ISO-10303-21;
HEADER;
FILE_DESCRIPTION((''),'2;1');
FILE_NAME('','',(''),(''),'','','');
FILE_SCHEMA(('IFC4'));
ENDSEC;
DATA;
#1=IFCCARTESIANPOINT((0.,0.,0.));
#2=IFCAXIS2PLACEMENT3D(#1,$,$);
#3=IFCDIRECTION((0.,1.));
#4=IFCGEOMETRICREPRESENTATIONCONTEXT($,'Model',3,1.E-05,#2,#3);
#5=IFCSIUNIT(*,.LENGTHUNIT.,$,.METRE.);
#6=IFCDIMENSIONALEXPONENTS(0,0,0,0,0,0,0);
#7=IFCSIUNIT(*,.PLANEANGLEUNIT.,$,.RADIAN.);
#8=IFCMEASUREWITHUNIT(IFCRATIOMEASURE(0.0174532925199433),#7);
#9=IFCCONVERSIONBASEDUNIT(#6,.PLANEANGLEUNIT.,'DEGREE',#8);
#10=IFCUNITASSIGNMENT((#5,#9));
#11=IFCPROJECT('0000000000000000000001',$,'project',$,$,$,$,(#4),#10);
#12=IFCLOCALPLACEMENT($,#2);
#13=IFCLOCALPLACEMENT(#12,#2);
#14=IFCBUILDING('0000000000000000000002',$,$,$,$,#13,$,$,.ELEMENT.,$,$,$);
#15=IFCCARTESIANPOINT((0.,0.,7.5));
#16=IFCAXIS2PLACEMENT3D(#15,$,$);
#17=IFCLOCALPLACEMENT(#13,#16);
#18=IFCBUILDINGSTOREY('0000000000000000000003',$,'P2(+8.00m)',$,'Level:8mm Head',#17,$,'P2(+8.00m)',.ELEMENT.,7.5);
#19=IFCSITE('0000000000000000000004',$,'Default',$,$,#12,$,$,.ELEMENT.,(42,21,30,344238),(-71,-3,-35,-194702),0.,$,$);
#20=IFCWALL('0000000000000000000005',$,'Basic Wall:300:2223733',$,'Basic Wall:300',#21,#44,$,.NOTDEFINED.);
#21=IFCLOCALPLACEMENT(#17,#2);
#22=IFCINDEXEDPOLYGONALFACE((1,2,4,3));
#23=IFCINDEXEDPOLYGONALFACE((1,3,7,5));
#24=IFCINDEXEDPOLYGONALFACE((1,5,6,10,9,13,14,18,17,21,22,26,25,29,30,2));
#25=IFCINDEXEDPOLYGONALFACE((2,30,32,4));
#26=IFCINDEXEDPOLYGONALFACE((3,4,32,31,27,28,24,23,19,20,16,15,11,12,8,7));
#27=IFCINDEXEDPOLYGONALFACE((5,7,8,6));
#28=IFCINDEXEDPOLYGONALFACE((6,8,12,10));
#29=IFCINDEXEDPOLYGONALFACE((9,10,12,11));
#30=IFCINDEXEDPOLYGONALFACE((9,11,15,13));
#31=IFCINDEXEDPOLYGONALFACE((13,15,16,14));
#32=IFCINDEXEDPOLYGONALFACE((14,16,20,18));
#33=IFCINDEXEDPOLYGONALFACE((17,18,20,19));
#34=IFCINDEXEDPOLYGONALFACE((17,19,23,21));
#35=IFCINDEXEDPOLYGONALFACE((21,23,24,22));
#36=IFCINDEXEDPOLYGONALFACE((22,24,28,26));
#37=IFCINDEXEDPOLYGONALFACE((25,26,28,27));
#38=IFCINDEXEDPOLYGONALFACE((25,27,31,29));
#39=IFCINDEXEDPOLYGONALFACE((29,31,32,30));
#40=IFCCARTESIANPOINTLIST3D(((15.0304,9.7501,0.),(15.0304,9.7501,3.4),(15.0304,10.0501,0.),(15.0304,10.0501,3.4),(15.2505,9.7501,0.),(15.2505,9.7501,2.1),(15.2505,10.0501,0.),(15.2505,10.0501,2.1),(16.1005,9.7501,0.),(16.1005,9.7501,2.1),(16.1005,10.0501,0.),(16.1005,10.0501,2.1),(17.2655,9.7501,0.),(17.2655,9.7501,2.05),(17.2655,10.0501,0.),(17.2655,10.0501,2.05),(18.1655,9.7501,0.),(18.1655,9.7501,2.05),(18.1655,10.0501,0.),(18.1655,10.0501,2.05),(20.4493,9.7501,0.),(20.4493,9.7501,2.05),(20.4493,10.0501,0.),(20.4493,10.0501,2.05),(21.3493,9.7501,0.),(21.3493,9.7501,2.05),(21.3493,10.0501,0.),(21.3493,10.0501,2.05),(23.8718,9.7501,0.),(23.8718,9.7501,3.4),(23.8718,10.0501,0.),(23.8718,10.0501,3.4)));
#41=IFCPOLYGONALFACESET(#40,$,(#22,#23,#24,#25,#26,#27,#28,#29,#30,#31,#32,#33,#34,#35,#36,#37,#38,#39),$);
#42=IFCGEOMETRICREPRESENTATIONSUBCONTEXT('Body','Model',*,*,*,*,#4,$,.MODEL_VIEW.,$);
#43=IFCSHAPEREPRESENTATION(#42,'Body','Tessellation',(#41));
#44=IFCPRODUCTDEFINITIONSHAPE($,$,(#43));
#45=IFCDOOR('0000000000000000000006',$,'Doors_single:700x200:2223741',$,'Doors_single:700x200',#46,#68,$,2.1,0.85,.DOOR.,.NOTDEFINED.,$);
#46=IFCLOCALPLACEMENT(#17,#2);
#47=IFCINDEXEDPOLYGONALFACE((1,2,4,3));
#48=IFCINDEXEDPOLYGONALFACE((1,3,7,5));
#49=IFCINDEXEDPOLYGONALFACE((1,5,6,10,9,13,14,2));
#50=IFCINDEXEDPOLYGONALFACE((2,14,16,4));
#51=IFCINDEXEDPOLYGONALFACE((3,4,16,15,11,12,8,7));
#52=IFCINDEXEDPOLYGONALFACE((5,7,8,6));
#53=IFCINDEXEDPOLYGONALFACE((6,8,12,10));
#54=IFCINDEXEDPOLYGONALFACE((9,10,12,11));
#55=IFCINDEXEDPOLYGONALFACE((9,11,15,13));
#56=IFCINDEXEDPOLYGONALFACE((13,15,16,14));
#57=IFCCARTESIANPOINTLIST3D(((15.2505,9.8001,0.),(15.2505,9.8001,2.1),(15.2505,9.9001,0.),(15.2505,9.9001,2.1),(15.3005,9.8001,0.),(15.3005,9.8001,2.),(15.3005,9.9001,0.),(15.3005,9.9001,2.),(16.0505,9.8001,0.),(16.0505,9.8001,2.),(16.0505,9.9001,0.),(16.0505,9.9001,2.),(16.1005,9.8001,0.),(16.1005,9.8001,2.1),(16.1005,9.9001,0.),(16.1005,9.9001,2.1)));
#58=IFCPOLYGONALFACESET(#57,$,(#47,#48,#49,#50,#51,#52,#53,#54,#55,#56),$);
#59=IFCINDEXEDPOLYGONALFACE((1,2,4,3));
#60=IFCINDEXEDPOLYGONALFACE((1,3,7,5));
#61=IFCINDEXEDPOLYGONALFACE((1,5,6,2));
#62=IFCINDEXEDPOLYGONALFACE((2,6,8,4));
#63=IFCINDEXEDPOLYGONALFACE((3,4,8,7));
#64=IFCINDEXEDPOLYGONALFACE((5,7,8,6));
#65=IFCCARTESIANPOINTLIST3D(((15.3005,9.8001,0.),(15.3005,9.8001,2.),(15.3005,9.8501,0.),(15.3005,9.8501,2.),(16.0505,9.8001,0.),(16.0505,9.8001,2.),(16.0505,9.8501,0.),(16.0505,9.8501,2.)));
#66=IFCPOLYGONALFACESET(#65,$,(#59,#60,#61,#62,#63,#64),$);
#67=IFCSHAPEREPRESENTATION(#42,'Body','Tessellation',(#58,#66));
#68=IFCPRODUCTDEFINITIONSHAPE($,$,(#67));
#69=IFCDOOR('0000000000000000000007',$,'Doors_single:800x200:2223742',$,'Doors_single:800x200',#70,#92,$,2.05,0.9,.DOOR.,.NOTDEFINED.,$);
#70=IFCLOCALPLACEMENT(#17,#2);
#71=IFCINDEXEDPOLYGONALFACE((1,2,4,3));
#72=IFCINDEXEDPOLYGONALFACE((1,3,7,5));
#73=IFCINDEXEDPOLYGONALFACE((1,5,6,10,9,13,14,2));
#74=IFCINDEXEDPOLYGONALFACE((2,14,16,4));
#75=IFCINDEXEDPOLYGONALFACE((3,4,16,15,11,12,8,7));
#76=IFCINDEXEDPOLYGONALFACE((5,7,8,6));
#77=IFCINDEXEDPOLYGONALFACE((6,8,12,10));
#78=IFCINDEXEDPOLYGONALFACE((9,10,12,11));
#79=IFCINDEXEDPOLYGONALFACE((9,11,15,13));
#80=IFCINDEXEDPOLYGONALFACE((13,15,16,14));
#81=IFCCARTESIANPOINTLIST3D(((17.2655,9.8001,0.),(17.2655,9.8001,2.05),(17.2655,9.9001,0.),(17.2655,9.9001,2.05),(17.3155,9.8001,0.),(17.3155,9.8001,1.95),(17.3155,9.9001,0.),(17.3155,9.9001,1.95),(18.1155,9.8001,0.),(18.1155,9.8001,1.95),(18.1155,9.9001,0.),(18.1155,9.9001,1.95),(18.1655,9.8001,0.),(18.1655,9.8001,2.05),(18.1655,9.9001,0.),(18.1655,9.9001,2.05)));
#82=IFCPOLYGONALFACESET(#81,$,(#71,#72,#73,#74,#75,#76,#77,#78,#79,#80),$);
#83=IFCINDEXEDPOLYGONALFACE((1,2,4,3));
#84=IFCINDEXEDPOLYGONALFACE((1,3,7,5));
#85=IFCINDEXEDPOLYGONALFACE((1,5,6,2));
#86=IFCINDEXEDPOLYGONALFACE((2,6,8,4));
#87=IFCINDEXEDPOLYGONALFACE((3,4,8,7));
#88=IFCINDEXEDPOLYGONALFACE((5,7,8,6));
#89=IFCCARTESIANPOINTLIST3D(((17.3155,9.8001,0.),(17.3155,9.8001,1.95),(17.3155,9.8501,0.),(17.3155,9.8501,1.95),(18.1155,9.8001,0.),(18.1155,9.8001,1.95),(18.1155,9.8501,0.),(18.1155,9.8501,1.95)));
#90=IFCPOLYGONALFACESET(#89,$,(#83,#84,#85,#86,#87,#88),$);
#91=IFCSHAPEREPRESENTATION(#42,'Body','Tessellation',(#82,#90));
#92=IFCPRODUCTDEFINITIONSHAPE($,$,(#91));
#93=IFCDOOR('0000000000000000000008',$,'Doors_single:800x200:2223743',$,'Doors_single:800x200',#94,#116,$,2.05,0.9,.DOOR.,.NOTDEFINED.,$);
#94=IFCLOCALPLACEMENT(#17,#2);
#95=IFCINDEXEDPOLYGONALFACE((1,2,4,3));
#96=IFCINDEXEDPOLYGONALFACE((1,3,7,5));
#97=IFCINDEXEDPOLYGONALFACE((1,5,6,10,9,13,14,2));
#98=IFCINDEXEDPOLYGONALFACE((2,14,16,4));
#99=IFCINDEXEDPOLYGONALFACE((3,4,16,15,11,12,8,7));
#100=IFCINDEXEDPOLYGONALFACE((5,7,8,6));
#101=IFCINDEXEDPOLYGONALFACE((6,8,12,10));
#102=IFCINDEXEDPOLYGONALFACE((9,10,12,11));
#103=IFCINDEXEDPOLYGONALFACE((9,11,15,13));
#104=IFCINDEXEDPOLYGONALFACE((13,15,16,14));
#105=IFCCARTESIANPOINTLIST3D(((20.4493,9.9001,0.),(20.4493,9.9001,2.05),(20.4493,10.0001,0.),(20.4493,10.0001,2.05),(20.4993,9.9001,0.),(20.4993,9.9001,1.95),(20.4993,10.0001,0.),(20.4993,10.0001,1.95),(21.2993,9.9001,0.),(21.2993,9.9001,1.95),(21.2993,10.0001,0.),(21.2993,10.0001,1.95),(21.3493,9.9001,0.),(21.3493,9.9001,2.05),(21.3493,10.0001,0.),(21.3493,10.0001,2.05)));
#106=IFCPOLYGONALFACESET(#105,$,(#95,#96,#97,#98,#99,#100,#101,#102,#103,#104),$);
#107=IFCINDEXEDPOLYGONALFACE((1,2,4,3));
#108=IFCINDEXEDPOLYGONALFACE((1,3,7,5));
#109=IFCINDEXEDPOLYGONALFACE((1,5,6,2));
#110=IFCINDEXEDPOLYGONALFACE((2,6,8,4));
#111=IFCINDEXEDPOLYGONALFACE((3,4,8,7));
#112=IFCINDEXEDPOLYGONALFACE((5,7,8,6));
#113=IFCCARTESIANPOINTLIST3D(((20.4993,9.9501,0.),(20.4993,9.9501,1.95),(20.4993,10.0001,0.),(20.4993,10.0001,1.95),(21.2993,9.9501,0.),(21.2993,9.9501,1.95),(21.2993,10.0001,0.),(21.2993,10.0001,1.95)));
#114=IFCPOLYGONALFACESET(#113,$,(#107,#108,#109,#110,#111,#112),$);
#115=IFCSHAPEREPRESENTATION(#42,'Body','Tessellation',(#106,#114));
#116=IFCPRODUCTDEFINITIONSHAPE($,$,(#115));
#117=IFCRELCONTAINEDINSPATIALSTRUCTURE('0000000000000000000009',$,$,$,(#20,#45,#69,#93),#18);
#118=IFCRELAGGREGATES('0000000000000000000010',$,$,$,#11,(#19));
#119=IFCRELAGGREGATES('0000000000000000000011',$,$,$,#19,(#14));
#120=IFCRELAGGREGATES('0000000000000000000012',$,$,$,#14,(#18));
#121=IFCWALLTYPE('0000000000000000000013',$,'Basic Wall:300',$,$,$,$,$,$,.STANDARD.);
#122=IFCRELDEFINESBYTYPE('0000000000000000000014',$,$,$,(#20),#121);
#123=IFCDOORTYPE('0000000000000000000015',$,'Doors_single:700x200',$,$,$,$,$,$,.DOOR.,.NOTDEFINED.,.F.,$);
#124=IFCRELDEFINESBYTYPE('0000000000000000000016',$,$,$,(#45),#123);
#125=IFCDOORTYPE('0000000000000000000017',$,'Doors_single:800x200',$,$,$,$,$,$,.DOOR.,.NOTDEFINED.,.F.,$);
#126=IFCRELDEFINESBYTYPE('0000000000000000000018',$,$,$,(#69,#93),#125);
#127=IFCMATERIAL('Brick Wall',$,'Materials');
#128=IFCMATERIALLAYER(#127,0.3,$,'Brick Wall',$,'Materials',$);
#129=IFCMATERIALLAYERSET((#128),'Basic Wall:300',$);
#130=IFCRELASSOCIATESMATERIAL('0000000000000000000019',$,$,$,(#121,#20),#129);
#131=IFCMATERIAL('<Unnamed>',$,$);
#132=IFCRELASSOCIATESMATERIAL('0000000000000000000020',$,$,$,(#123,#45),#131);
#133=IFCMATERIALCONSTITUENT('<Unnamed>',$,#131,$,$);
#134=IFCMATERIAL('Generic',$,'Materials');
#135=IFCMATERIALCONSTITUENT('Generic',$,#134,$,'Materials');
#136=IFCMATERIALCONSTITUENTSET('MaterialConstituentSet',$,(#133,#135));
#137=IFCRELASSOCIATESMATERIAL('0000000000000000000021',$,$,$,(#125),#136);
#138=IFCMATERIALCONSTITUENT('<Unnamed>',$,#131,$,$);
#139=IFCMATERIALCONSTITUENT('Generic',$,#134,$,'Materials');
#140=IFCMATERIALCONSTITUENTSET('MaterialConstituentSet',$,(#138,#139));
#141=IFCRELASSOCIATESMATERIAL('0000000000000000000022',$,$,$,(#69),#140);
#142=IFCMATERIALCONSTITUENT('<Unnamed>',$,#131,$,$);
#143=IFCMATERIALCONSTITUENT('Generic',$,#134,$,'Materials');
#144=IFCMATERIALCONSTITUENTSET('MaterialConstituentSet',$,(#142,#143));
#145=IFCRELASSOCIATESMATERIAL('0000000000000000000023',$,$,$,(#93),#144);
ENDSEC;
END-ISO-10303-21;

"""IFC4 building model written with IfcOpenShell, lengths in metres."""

from ifc_helpers import new_model, entity, si_unit, converted_unit, direction, frame, frame_2d, origin, place, context, subcontext, project, spatial, polyline, rectangle, outline, extrude, source, transform, mapped, material, layer, layer_set, layer_usage, constituent, constituent_set, type_object, type_shapes, element, fill, save


model = new_model("IFC4")

# Units and contexts
model_context = context("Model", 3, precision=1e-05, world=origin(), true_north=direction((0.0, 1.0)))
body_context = subcontext(model_context, "Body", "Model", "MODEL_VIEW")
ifc_project = project(units=[si_unit("LENGTHUNIT", "METRE"), converted_unit("PLANEANGLEUNIT", "DEGREE", entity("IfcRatioMeasure", 0.0174532925199433), si_unit("PLANEANGLEUNIT", "RADIAN"), dimensions=[0, 0, 0, 0, 0, 0, 0])], contexts=[model_context])

# Site, building, storey
site_placement = place(None, origin())
site = spatial("IfcSite", under=ifc_project, at=site_placement, Name="Default", CompositionType="ELEMENT", RefLatitude=(42, 21, 30, 344238), RefLongitude=(-71, -3, -35, -194702), RefElevation=0.0)
building_placement = place(site_placement, origin())
building = spatial("IfcBuilding", under=site, at=building_placement, CompositionType="ELEMENT")
storey_placement = place(building_placement, frame((0.0, 0.0, 7.5)))
storey = spatial("IfcBuildingStorey", under=building, at=storey_placement, Name="P2(+8.00m)", ObjectType="Level:8mm Head", LongName="P2(+8.00m)", CompositionType="ELEMENT", Elevation=7.5)

# Shared definitions
ifc_material_1 = material(Name="Brick Wall", Category="Materials")
ifc_material_2 = material(Name="<Unnamed>")
ifc_material_3 = material(Name="Generic", Category="Materials")

# Wall, openings, doors
ifc_layer_1 = layer(ifc_material_1, 0.3, Name="Brick Wall", Category="Materials")
ifc_layer_set_1 = layer_set([ifc_layer_1], Name="Basic Wall:300")
ifc_layer_usage_1 = layer_usage(ifc_layer_set_1, "AXIS2", "POSITIVE", -0.15)
wall_type_1 = type_object("IfcWallType", Name="Basic Wall:300", PredefinedType="STANDARD", material=ifc_layer_set_1)
wall_1_placement = place(storey_placement, frame((15.0304, 9.9001, 0.0)))
wall_1 = element("IfcWall", 1, at=wall_1_placement, inside=storey, type_object=wall_type_1, material=ifc_layer_usage_1, Name="Basic Wall:300:2223733", ObjectType="Basic Wall:300", PredefinedType="NOTDEFINED", context=body_context, shape_type="SweptSolid", body=[
    extrude(rectangle(XDim=8.8414, YDim=0.3, at=frame_2d((4.4207, 0.0), x_axis=(-1.0, 0.0))), origin(), (0.0, 0.0, 1.0), 3.4),
])
opening_1_placement = place(wall_1_placement, frame((5.4188, -0.15, 0.0)))
opening_1 = element("IfcOpeningElement", 2, at=opening_1_placement, cuts=wall_1, PredefinedType="OPENING", context=body_context, shape_type="SweptSolid", body=[
    extrude(rectangle(XDim=2.05, YDim=0.9, at=frame_2d((1.025, 0.45), x_axis=(1.0, 0.0))), frame((0.0, 0.0, 0.0), z_axis=(0.0, 1.0, 0.0), x_axis=(0.0, 0.0, 1.0)), (0.0, 0.0, 1.0), 0.3),
])
opening_2_placement = place(wall_1_placement, frame((3.1351, 0.15, 0.0)))
opening_2 = element("IfcOpeningElement", 3, at=opening_2_placement, cuts=wall_1, PredefinedType="OPENING", context=body_context, shape_type="SweptSolid", body=[
    extrude(rectangle(XDim=2.05, YDim=0.9, at=frame_2d((1.025, 0.45), x_axis=(1.0, 0.0))), frame((0.0, 0.0, 0.0), z_axis=(0.0, -1.0, 0.0), x_axis=(0.0, 0.0, 1.0)), (0.0, 0.0, 1.0), 0.3),
])
opening_3_placement = place(wall_1_placement, frame((1.0701, 0.15, 0.0)))
opening_3 = element("IfcOpeningElement", 4, at=opening_3_placement, cuts=wall_1, PredefinedType="OPENING", context=body_context, shape_type="SweptSolid", body=[
    extrude(rectangle(XDim=2.1, YDim=0.85, at=frame_2d((1.05, 0.425), x_axis=(1.0, 0.0))), frame((0.0, 0.0, 0.0), z_axis=(0.0, -1.0, 0.0), x_axis=(0.0, 0.0, 1.0)), (0.0, 0.0, 1.0), 0.3),
])
door_type_1 = type_object("IfcDoorType", Name="Doors_single:700x200", OperationType="NOTDEFINED", ParameterTakesPrecedence=False, PredefinedType="DOOR", material=ifc_material_2)
shared_shape_1 = source(origin(), body_context, "Body", "SweptSolid", [
    extrude(outline(polyline([(-0.425, -1.025), (-0.375, -1.025), (-0.375, 0.975), (0.375, 0.975), (0.375, -1.025), (0.425, -1.025), (0.425, 1.075), (-0.425, 1.075), (-0.425, -1.025)])), frame((0.425, 0.25, 1.025), z_axis=(0.0, -1.0, 0.0), x_axis=(1.0, 0.0, 0.0)), (0.0, 0.0, 1.0), 0.1),
    extrude(rectangle(XDim=0.05, YDim=0.75, at=frame_2d((0.0, 0.0), x_axis=(1.0, 0.0))), frame((0.425, 0.225, 0.0), z_axis=(0.0, 0.0, 1.0), x_axis=(0.0, -1.0, 0.0)), (0.0, 0.0, 1.0), 2.0),
])
type_shapes(door_type_1, [shared_shape_1])
door_1_placement = place(opening_3_placement, frame((0.0, 0.0, 0.0), z_axis=(0.0, 0.0, 1.0), x_axis=(-1.0, 0.0, 0.0)))
door_1 = element("IfcDoor", 5, at=door_1_placement, inside=storey, type_object=door_type_1, material=ifc_material_2, Name="Doors_single:700x200:2223741", ObjectType="Doors_single:700x200", OperationType="NOTDEFINED", OverallHeight=2.1, OverallWidth=0.85, PredefinedType="DOOR", context=body_context, shape_type="MappedRepresentation", body=[
    mapped(shared_shape_1, transform((0.0, 0.0, 0.0), scale=1.0)),
])
fill(opening_3, door_1)
ifc_constituent_1 = constituent(ifc_material_2, Name="<Unnamed>")
ifc_constituent_2 = constituent(ifc_material_3, Name="Generic", Category="Materials")
ifc_constituent_set_1 = constituent_set(constituents=[ifc_constituent_1, ifc_constituent_2], Name="MaterialConstituentSet")
ifc_constituent_3 = constituent(ifc_material_2, Name="<Unnamed>")
ifc_constituent_4 = constituent(ifc_material_3, Name="Generic", Category="Materials")
ifc_constituent_set_2 = constituent_set(constituents=[ifc_constituent_3, ifc_constituent_4], Name="MaterialConstituentSet")
door_type_2 = type_object("IfcDoorType", Name="Doors_single:800x200", OperationType="NOTDEFINED", ParameterTakesPrecedence=False, PredefinedType="DOOR", material=ifc_constituent_set_2)
shared_shape_2 = source(origin(), body_context, "Body", "SweptSolid", [
    extrude(outline(polyline([(-0.45, -1.0), (-0.4, -1.0), (-0.4, 0.95), (0.4, 0.95), (0.4, -1.0), (0.45, -1.0), (0.45, 1.05), (-0.45, 1.05), (-0.45, -1.0)])), frame((0.45, 0.15, 1.0), z_axis=(0.0, 1.0, 0.0), x_axis=(-1.0, 0.0, 0.0)), (0.0, 0.0, 1.0), 0.1),
    extrude(rectangle(XDim=0.8, YDim=0.05, at=frame_2d((0.0, 0.0), x_axis=(1.0, 0.0))), frame((0.45, 0.225, 0.0), z_axis=(0.0, 0.0, 1.0), x_axis=(-1.0, 0.0, 0.0)), (0.0, 0.0, 1.0), 1.95),
])
type_shapes(door_type_2, [shared_shape_2])
door_2_placement = place(opening_2_placement, frame((0.0, 0.0, 0.0), z_axis=(0.0, 0.0, 1.0), x_axis=(-1.0, 0.0, 0.0)))
door_2 = element("IfcDoor", 6, at=door_2_placement, inside=storey, type_object=door_type_2, material=ifc_constituent_set_1, Name="Doors_single:800x200:2223742", ObjectType="Doors_single:800x200", OperationType="NOTDEFINED", OverallHeight=2.05, OverallWidth=0.9, PredefinedType="DOOR", context=body_context, shape_type="MappedRepresentation", body=[
    mapped(shared_shape_2, transform((0.0, 0.0, 0.0), scale=1.0)),
])
fill(opening_2, door_2)
ifc_constituent_5 = constituent(ifc_material_2, Name="<Unnamed>")
ifc_constituent_6 = constituent(ifc_material_3, Name="Generic", Category="Materials")
ifc_constituent_set_3 = constituent_set(constituents=[ifc_constituent_5, ifc_constituent_6], Name="MaterialConstituentSet")
door_3_placement = place(opening_1_placement, origin())
door_3 = element("IfcDoor", 7, at=door_3_placement, inside=storey, type_object=door_type_2, material=ifc_constituent_set_3, Name="Doors_single:800x200:2223743", ObjectType="Doors_single:800x200", OperationType="NOTDEFINED", OverallHeight=2.05, OverallWidth=0.9, PredefinedType="DOOR", context=body_context, shape_type="MappedRepresentation", body=[
    mapped(shared_shape_2, transform((0.0, 0.0, 0.0), scale=1.0)),
])
fill(opening_1, door_3)

save(model, "model.ifc")
